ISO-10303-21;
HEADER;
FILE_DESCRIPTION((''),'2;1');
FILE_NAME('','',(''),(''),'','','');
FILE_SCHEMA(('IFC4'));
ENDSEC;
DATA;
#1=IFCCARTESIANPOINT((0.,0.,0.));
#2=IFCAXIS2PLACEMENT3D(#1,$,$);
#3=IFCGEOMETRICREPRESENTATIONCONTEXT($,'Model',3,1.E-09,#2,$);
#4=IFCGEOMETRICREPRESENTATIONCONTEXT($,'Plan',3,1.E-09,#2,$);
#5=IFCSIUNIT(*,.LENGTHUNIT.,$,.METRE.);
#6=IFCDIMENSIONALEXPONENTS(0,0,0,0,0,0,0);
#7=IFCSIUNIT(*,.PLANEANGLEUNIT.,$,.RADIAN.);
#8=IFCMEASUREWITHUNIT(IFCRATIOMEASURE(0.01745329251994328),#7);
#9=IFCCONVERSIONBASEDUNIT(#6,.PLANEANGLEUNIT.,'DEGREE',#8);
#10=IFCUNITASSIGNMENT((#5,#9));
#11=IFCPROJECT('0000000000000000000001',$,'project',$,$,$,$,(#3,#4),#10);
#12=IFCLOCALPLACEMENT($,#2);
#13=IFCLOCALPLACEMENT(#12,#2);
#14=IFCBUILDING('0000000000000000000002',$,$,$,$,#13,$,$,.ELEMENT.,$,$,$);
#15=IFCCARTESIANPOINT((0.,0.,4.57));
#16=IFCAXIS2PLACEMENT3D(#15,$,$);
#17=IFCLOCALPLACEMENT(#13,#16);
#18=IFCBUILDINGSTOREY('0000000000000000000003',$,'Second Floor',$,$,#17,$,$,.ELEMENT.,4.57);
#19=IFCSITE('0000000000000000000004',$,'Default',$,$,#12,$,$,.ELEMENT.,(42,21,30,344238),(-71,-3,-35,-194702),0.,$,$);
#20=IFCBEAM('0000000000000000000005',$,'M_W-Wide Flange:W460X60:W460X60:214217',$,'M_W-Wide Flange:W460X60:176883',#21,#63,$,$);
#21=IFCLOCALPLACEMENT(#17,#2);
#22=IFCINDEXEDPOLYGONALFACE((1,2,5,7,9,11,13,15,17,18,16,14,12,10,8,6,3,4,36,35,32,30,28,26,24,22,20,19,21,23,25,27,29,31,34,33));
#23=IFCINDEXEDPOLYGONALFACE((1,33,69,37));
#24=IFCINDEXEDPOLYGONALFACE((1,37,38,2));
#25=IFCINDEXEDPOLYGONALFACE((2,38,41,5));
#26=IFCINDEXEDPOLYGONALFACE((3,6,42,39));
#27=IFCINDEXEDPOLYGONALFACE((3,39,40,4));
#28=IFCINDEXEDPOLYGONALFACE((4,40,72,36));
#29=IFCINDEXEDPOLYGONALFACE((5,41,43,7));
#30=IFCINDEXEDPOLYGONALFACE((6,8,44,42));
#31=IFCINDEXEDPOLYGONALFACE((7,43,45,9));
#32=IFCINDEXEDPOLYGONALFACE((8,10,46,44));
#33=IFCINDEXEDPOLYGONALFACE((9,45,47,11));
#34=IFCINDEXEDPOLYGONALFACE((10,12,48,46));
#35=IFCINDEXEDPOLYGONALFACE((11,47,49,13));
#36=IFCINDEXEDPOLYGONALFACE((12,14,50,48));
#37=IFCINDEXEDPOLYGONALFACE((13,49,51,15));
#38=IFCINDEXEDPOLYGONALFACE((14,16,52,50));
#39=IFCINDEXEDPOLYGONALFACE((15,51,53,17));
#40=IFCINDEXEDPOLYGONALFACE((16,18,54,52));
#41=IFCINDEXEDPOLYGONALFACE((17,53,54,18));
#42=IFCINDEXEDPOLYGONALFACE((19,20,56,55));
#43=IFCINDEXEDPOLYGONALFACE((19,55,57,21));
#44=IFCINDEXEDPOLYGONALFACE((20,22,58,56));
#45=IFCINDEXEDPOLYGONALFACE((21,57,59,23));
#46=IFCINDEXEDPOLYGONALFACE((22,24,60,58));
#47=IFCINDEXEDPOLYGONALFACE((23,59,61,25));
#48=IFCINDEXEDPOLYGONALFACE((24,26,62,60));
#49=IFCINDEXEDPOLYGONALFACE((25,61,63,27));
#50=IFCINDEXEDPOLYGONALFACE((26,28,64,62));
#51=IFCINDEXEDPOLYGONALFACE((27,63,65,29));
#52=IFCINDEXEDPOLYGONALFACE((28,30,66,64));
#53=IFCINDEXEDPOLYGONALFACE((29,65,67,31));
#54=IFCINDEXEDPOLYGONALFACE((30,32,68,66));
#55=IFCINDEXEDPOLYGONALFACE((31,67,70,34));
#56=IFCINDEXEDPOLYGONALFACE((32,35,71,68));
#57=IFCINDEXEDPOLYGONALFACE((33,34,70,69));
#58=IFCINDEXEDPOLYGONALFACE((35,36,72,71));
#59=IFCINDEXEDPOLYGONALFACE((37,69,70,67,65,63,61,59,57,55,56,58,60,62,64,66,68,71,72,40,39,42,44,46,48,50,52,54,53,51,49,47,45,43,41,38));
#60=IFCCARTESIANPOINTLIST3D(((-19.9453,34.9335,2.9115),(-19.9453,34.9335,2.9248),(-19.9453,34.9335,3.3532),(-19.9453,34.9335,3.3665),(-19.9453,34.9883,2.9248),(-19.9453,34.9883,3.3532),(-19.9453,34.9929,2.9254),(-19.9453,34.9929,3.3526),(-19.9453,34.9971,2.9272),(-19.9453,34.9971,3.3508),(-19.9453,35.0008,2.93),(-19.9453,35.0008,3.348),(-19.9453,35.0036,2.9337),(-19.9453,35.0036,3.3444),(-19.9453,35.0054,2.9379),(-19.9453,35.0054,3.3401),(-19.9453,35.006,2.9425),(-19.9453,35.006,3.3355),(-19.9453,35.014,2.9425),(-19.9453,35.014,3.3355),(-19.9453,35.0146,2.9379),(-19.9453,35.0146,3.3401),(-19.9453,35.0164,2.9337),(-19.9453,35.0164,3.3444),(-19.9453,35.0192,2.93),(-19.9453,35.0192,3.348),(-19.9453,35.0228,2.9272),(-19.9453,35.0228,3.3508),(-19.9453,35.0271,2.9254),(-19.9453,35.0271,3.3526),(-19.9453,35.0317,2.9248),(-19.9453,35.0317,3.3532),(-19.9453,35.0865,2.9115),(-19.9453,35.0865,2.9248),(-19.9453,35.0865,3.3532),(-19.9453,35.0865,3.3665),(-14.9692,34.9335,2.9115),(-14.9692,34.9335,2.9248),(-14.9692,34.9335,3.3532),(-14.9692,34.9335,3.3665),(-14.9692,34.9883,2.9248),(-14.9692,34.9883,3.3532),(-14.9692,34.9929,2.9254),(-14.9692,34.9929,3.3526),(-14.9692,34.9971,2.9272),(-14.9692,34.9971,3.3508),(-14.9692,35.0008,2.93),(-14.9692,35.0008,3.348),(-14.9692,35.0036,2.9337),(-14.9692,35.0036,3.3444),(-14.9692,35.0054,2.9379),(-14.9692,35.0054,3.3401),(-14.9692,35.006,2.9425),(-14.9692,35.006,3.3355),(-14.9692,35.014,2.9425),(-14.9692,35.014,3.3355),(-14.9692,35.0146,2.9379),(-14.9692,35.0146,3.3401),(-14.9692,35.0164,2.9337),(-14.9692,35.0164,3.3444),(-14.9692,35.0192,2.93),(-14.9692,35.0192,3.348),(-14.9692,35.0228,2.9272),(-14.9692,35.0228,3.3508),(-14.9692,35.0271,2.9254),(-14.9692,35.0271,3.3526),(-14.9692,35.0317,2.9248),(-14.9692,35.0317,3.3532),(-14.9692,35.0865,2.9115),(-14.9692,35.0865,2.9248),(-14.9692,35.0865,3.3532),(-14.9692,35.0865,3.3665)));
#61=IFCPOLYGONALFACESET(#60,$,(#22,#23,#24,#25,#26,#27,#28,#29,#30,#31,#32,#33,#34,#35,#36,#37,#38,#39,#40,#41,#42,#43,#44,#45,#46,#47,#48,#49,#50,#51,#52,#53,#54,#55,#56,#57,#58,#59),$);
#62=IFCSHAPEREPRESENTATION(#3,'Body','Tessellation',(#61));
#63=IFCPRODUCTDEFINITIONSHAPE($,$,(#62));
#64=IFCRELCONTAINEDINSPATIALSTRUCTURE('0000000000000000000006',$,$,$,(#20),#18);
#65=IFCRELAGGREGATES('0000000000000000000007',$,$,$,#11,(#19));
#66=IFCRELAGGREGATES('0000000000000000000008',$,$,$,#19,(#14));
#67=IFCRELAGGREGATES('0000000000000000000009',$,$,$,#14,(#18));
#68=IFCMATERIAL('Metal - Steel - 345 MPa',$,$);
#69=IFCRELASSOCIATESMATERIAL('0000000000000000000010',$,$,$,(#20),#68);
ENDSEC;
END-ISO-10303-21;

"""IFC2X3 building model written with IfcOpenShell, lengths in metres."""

from ifc_helpers import new_model, entity, si_unit, converted_unit, frame, frame_2d, origin, place, context, project, spatial, polyline, circle_curve, parameter, trimmed, segment, composite_curve, outline, extrude, material, element, save


model = new_model("IFC2X3")

# Units and contexts
model_context = context("Model", 3, precision=1e-09, world=origin())
plan_context = context("Plan", 3, precision=1e-09, world=origin())
ifc_project = project(units=[si_unit("LENGTHUNIT", "METRE"), converted_unit("PLANEANGLEUNIT", "DEGREE", entity("IfcRatioMeasure", 0.01745329251994328), si_unit("PLANEANGLEUNIT", "RADIAN"), dimensions=[0, 0, 0, 0, 0, 0, 0])], contexts=[model_context, plan_context])

# Site, building, storey
site_placement = place(None, origin())
site = spatial("IfcSite", under=ifc_project, at=site_placement, Name="Default", CompositionType="ELEMENT", RefLatitude=(42, 21, 30, 344238), RefLongitude=(-71, -3, -35, -194702), RefElevation=0.0)
building_placement = place(site_placement, origin())
building = spatial("IfcBuilding", under=site, at=building_placement, CompositionType="ELEMENT")
storey_placement = place(building_placement, frame((0.0, 0.0, 4.57)))
storey = spatial("IfcBuildingStorey", under=building, at=storey_placement, Name="Second Floor", CompositionType="ELEMENT", Elevation=4.57)

# Shared definitions
ifc_material = material(Name="Metal - Steel - 345 MPa")

# Beam
beam_1_placement = place(storey_placement, frame((-13.8043, 35.01, 3.3665), z_axis=(0.0, 0.0, 1.0), x_axis=(0.0, 1.0, 0.0)))
element("IfcBeam", 1, at=beam_1_placement, inside=storey, material=ifc_material, Name="M_W-Wide Flange:W460X60:W460X60:214217", ObjectType="M_W-Wide Flange:W460X60:176883", context=model_context, shape_type="SweptSolid", body=[
    extrude(outline(composite_curve([segment(polyline([(0.2142, -0.0765), (0.2275, -0.0765)]), True, "CONTINUOUS"), segment(polyline([(0.2275, -0.0765), (0.2275, 0.0765)]), True, "CONTINUOUS"), segment(polyline([(0.2275, 0.0765), (0.2142, 0.0765)]), True, "CONTINUOUS"), segment(polyline([(0.2142, 0.0765), (0.2142, 0.0217)]), True, "CONTINUOUS"), segment(trimmed(circle_curve(frame_2d((0.1965, 0.0217), x_axis=(0.0, 1.0)), 0.0177), [parameter(180.0)], [parameter(270.0)], True, "PARAMETER"), False, "CONTINUOUS"), segment(polyline([(0.1965, 0.004), (-0.1965, 0.004)]), True, "CONTINUOUS"), segment(trimmed(circle_curve(frame_2d((-0.1965, 0.0217), x_axis=(0.0, 1.0)), 0.0177), [parameter(90.0)], [parameter(180.0)], True, "PARAMETER"), False, "CONTINUOUS"), segment(polyline([(-0.2142, 0.0217), (-0.2142, 0.0765)]), True, "CONTINUOUS"), segment(polyline([(-0.2142, 0.0765), (-0.2275, 0.0765)]), True, "CONTINUOUS"), segment(polyline([(-0.2275, 0.0765), (-0.2275, -0.0765)]), True, "CONTINUOUS"), segment(polyline([(-0.2275, -0.0765), (-0.2142, -0.0765)]), True, "CONTINUOUS"), segment(polyline([(-0.2142, -0.0765), (-0.2142, -0.0217)]), True, "CONTINUOUS"), segment(trimmed(circle_curve(frame_2d((-0.1965, -0.0217), x_axis=(0.0, 1.0)), 0.0177), [parameter(360.0)], [parameter(90.0)], True, "PARAMETER"), False, "CONTINUOUS"), segment(polyline([(-0.1965, -0.004), (0.1965, -0.004)]), True, "CONTINUOUS"), segment(trimmed(circle_curve(frame_2d((0.1965, -0.0217), x_axis=(0.0, 1.0)), 0.0177), [parameter(270.0)], [parameter(0.0)], True, "PARAMETER"), False, "CONTINUOUS"), segment(polyline([(0.2142, -0.0217), (0.2142, -0.0765)]), True, "CONTINUOUS")], self_intersect=False)), frame((0.0, 6.141, -0.2275), z_axis=(0.0, -1.0, 0.0), x_axis=(0.0, 0.0, -1.0)), (0.0, 0.0, 1.0), 4.9761),
])

save(model, "model.ifc")
